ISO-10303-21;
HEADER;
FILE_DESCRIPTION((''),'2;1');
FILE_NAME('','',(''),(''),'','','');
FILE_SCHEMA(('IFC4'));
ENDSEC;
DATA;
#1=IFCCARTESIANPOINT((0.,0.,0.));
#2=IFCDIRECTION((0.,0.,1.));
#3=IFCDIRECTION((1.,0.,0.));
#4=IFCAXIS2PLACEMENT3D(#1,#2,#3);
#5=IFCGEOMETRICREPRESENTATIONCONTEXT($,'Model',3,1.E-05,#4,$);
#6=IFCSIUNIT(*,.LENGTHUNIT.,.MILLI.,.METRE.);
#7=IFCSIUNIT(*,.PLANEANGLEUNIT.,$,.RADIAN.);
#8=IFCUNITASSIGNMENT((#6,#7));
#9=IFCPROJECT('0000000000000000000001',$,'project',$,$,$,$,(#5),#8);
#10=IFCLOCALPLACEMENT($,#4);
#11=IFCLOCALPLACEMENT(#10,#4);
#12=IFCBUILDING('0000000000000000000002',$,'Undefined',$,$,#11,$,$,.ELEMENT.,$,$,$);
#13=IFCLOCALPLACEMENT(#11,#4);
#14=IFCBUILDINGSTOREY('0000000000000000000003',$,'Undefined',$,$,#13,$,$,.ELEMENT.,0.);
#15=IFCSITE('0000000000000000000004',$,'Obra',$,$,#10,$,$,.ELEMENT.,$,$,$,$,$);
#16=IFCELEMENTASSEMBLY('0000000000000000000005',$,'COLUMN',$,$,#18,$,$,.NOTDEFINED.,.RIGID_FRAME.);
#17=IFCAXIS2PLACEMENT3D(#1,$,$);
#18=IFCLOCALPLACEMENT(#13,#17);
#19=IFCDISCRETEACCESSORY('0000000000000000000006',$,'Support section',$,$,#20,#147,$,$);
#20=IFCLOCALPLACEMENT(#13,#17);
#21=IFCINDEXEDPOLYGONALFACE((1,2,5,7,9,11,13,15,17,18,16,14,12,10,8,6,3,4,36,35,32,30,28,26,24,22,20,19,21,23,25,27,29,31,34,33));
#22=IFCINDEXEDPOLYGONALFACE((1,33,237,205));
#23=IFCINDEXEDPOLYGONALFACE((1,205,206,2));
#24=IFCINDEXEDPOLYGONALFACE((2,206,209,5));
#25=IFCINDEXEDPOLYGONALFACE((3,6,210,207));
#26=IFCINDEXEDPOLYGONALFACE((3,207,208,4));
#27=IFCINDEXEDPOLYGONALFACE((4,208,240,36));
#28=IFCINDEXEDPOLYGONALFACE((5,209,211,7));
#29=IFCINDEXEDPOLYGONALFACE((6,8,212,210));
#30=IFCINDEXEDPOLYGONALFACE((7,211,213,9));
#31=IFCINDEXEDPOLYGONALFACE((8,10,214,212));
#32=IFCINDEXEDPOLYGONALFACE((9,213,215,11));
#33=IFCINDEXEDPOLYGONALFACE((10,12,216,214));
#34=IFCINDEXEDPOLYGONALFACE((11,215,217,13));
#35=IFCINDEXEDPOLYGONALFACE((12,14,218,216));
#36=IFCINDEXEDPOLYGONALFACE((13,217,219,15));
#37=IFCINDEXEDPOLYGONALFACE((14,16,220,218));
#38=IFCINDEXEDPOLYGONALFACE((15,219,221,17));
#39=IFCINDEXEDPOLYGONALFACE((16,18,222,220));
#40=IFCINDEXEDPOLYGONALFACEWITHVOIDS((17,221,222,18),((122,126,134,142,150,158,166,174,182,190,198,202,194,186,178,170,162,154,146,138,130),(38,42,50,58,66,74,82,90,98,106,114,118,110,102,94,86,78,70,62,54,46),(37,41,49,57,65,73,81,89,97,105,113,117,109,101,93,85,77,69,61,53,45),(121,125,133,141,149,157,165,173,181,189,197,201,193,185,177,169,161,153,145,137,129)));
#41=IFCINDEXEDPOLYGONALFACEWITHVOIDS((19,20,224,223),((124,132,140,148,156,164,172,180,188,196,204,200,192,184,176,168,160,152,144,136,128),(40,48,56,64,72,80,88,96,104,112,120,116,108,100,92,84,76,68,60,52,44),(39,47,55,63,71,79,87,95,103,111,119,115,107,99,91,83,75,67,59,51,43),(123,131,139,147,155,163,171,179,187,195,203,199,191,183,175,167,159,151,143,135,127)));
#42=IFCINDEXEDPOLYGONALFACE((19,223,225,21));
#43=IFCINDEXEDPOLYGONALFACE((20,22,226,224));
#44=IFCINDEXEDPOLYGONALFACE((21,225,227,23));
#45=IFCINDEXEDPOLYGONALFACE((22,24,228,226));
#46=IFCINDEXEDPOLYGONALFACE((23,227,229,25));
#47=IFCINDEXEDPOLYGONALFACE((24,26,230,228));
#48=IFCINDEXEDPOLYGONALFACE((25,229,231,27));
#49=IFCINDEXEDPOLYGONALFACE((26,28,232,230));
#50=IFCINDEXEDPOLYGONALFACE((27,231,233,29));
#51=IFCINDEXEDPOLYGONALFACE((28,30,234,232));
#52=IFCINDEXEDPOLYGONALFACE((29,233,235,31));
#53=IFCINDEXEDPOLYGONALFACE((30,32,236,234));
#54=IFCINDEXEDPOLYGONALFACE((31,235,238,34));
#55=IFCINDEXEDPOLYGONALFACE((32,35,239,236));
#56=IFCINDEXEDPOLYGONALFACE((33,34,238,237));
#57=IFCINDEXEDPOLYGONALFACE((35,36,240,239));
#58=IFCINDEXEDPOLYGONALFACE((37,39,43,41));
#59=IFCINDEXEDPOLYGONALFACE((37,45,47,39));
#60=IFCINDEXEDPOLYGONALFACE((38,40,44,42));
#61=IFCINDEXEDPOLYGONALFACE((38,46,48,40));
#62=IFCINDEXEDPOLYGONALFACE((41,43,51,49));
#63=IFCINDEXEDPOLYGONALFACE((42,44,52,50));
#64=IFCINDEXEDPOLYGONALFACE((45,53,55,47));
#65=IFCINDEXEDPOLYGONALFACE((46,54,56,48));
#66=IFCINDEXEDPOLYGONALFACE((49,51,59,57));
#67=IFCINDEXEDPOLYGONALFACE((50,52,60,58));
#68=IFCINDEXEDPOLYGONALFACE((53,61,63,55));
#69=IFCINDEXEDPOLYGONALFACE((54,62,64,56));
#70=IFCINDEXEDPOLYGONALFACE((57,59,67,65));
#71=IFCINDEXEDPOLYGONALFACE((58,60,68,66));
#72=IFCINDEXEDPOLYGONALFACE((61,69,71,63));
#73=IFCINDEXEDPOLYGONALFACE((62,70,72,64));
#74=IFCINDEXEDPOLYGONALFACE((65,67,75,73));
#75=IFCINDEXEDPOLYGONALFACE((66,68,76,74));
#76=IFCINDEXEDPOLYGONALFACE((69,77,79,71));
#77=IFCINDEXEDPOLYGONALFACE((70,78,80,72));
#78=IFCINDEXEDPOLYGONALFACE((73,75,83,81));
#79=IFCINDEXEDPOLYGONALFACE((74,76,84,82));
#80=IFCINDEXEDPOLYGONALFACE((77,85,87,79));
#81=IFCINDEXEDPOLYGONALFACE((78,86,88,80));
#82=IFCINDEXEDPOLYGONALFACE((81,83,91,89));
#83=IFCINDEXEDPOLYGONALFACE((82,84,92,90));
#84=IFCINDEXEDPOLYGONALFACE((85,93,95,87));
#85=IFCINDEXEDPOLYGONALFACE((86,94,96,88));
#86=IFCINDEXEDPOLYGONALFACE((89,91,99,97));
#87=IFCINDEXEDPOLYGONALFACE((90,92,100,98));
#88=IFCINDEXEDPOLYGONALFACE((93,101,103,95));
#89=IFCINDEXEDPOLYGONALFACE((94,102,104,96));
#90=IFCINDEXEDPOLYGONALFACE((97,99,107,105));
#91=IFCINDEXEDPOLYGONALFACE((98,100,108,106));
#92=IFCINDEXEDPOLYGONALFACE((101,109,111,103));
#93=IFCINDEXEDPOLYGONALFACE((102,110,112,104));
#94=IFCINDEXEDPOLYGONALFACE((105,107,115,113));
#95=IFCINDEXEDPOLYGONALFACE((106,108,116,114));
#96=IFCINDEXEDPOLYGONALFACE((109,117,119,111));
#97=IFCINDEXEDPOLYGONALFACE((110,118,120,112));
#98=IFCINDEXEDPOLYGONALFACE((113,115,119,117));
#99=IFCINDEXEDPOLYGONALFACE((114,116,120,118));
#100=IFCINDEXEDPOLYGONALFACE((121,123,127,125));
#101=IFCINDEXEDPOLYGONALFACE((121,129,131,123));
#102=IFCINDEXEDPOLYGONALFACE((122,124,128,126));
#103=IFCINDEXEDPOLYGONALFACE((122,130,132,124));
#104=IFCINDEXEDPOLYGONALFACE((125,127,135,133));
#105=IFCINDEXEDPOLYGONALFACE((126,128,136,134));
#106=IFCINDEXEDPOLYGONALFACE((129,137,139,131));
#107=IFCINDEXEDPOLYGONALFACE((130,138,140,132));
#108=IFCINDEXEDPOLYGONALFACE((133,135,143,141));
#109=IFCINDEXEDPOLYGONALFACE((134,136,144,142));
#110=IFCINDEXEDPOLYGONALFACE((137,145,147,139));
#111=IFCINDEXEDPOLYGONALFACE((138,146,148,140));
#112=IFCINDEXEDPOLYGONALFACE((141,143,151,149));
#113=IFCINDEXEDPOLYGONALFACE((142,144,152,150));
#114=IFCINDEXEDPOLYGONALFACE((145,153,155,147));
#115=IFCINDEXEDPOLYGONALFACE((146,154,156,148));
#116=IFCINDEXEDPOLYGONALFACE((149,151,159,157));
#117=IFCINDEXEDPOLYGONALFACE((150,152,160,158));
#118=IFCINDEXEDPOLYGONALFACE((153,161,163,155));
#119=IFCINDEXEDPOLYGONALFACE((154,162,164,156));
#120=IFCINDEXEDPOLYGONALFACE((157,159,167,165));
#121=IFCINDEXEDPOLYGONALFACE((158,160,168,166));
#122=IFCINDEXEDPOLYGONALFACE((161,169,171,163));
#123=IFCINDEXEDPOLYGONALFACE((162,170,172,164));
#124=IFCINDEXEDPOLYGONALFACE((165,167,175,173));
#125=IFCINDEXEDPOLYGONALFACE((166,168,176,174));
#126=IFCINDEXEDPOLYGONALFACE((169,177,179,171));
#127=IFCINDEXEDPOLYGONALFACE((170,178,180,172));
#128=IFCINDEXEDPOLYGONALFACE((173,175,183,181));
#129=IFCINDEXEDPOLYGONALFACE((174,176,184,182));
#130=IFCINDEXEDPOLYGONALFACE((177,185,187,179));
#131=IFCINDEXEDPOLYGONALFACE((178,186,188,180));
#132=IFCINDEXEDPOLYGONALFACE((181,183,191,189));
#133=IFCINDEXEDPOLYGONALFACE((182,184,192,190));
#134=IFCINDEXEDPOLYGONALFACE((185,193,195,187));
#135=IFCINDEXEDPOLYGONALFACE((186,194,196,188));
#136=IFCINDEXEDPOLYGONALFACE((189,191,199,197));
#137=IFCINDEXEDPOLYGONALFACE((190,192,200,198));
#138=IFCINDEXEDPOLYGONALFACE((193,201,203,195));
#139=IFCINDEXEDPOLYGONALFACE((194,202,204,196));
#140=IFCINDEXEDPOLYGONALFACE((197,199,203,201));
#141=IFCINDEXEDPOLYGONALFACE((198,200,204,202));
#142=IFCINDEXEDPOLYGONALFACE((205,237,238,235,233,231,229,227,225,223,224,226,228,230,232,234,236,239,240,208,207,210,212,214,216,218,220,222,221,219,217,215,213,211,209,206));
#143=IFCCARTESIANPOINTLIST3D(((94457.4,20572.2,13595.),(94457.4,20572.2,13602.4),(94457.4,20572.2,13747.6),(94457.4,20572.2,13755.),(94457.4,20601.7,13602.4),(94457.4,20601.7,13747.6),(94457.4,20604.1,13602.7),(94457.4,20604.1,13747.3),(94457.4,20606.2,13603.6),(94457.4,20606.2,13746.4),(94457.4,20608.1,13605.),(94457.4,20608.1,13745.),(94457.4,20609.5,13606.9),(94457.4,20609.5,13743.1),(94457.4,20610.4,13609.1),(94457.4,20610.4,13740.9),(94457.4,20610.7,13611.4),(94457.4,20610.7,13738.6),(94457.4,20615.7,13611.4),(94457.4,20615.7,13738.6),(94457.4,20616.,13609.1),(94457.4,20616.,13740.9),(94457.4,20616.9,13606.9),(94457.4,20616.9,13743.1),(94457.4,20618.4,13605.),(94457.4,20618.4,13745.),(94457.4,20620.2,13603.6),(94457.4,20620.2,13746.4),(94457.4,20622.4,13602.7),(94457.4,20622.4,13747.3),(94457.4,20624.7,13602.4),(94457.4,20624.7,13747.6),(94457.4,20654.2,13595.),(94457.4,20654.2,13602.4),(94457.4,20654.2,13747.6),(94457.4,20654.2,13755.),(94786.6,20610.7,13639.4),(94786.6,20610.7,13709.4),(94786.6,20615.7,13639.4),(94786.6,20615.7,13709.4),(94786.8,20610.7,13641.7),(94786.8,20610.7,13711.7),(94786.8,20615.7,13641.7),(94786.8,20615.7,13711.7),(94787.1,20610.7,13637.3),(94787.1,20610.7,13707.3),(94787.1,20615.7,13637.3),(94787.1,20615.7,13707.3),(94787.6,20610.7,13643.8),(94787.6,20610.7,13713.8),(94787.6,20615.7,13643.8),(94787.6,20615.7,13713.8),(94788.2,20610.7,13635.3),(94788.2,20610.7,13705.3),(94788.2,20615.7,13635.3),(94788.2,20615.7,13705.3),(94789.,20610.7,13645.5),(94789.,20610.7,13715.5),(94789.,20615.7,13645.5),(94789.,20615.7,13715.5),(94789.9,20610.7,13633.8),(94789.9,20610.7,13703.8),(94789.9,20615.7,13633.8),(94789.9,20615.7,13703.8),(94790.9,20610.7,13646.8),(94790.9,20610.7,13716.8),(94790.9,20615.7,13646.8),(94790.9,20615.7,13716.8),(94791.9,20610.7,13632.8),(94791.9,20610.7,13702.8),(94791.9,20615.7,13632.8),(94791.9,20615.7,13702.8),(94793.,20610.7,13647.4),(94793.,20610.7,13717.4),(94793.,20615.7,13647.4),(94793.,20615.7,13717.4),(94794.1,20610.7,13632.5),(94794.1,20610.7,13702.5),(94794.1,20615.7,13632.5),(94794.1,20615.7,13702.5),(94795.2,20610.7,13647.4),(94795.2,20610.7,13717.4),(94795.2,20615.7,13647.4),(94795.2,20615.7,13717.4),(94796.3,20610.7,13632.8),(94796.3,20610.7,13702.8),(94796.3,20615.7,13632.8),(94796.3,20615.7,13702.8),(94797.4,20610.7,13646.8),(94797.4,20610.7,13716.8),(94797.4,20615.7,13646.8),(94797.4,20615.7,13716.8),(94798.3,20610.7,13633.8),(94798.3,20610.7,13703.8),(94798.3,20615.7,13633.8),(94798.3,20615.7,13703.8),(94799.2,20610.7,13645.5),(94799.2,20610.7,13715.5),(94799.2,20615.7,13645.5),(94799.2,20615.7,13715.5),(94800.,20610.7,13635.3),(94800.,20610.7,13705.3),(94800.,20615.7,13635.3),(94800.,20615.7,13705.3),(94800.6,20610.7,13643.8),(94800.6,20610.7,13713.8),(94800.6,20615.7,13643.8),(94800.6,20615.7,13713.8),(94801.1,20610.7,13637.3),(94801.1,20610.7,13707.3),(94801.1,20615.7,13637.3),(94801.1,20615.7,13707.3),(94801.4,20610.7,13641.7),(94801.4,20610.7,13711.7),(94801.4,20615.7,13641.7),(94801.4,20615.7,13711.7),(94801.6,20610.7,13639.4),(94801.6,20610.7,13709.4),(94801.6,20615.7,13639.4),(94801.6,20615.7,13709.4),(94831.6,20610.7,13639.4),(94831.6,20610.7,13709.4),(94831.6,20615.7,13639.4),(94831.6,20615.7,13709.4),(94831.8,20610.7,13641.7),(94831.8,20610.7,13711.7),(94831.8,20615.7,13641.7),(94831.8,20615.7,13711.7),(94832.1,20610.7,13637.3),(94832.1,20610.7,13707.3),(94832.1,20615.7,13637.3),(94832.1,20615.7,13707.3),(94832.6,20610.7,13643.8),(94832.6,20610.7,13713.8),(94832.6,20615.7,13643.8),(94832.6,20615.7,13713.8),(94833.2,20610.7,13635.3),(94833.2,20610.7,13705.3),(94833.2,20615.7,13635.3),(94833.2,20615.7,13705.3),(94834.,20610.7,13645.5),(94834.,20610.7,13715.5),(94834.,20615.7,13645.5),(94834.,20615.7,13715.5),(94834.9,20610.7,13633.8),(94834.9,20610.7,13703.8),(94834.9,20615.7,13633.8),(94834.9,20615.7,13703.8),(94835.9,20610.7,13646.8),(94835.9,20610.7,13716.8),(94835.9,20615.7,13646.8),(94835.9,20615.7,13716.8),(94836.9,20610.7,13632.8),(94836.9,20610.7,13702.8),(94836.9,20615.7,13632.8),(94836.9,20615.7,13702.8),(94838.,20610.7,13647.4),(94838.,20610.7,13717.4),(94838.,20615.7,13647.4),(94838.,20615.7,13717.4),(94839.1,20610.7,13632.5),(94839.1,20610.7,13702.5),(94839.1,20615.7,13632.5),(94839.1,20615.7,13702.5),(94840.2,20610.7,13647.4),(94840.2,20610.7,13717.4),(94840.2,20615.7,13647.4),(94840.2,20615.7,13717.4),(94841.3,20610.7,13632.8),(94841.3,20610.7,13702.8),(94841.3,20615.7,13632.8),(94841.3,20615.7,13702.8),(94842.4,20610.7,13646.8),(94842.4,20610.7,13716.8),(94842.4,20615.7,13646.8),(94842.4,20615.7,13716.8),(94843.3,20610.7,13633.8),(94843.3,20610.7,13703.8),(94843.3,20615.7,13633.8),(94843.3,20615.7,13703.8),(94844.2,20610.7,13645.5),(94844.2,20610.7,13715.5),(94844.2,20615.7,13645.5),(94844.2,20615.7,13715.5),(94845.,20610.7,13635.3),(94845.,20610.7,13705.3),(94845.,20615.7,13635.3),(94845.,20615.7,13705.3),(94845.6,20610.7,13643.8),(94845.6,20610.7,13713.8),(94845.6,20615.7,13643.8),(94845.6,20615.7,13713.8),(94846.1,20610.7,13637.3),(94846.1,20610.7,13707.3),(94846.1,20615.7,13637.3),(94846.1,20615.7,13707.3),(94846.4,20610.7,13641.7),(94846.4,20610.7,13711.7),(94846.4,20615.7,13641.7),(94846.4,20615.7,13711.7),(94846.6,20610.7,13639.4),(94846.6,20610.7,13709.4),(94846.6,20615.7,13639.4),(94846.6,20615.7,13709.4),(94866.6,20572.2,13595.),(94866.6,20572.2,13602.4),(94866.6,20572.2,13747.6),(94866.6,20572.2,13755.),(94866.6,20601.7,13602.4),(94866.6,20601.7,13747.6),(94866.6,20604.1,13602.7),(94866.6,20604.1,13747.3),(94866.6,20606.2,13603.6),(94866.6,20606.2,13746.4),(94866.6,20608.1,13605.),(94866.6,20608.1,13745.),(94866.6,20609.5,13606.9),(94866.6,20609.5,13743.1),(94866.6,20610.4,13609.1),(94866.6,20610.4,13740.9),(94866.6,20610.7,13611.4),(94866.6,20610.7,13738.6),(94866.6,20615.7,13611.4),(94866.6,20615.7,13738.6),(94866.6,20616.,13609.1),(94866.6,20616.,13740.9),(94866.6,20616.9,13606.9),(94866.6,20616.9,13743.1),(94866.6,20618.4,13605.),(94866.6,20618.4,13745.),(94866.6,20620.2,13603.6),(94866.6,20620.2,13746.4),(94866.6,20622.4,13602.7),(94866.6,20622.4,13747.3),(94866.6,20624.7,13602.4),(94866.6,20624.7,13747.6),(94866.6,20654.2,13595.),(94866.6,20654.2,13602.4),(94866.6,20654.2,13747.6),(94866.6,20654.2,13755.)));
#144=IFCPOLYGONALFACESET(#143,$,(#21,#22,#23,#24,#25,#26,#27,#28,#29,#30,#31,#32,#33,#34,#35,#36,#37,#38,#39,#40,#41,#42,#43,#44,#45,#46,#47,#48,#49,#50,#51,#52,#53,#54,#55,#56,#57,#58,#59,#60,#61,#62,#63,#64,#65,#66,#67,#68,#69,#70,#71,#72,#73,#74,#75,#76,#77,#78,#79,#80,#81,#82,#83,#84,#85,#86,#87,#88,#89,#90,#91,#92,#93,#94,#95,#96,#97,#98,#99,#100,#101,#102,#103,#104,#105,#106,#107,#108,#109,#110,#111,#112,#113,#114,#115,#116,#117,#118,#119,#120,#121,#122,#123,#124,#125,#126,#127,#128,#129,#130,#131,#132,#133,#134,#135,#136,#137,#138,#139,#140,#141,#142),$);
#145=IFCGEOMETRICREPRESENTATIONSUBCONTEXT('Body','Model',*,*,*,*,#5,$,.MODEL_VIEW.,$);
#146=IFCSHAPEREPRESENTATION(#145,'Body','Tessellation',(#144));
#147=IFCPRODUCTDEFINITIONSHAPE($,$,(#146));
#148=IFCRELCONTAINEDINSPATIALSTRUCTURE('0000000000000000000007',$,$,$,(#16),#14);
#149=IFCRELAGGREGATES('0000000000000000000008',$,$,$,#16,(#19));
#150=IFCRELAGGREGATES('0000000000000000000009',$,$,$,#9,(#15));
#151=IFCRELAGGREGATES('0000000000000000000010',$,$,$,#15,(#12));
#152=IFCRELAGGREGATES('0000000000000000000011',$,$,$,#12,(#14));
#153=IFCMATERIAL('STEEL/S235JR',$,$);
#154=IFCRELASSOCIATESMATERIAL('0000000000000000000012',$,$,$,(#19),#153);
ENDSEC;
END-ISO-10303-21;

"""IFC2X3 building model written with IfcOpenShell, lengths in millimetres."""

from ifc_helpers import new_model, si_unit, frame, origin_with_axes, origin_2d_with_axis, place, context, subcontext, project, spatial, circle, i_section, extrude, clip, halfspace, source, transform, mapped, material, element, aggregate, save


model = new_model("IFC2X3")

# Units and contexts
model_context = context("Model", 3, precision=1e-05, world=origin_with_axes())
body_context = subcontext(model_context, "Body", "Model", "MODEL_VIEW")
ifc_project = project(units=[si_unit("LENGTHUNIT", "METRE", prefix="MILLI"), si_unit("PLANEANGLEUNIT", "RADIAN")], contexts=[model_context])

# Site, building, storey
site_placement = place(None, origin_with_axes())
site = spatial("IfcSite", under=ifc_project, at=site_placement, Name="Obra", CompositionType="ELEMENT")
building_placement = place(site_placement, origin_with_axes())
building = spatial("IfcBuilding", under=site, at=building_placement, Name="Undefined", CompositionType="ELEMENT")
storey_placement = place(building_placement, origin_with_axes())
storey = spatial("IfcBuildingStorey", under=building, at=storey_placement, Name="Undefined", CompositionType="ELEMENT", Elevation=0.0)

# Shared definitions
ifc_material_1 = material(Name="STEEL/S235JR")

# Element assembly, discrete accessory, opening
assembly_1_placement = place(storey_placement, origin_with_axes())
assembly_1 = element("IfcElementAssembly", 1, at=assembly_1_placement, inside=storey, Name="COLUMN", AssemblyPlace="NOTDEFINED", PredefinedType="RIGID_FRAME")
shared_shape_1 = source(origin_with_axes(), body_context, "Body", "SweptSolid", [
    extrude(circle(Radius=7.5, at=origin_2d_with_axis()), frame((0.0, -2.6, 0.0), z_axis=(0.0, 1.0, 0.0), x_axis=(1.0, 0.0, 0.0)), (0.0, 0.0, 1.0), 5.2),
])
discrete_accessory_1_placement = place(assembly_1_placement, frame((94458.3, 20613.2, 13675.0), z_axis=(0.0, 0.0, 1.0), x_axis=(1.0, 0.0, 0.0)))
discrete_accessory_1 = element("IfcDiscreteAccessory", 2, at=discrete_accessory_1_placement, material=ifc_material_1, Name="Support section", context=body_context, shape_type="Clipping", body=[
    clip(clip(extrude(i_section(OverallWidth=82.0, OverallDepth=160.0, WebThickness=5.0, FlangeThickness=7.4, FilletRadius=9.0, at=origin_2d_with_axis()), frame((408.3, 0.0, 0.0), z_axis=(-1.0, 0.0, 0.0), x_axis=(0.0, -1.0, 0.0)), (0.0, 0.0, 1.0), 409.2), halfspace(frame((408.3, 0.0, -180.0), z_axis=(-1.0, 0.0, 0.0), x_axis=(0.0, 1.0, 0.0)), True)), halfspace(frame((-0.9, 0.0, 580.0), z_axis=(-1.0, -0.000033, 0.0), x_axis=(0.000033, -1.0, 0.0)), False)),
])
opening_1_placement = place(assembly_1_placement, frame((94816.6, 20613.2, 13710.0), z_axis=(-1.0, 0.0, 0.0), x_axis=(0.0, 0.0, -1.0)))
element("IfcOpeningElement", 3, at=opening_1_placement, cuts=discrete_accessory_1, ObjectType="Opening", context=body_context, shape_type="MappedRepresentation", body=[
    mapped(shared_shape_1, transform((0.0, 0.0, -22.5))),
    mapped(shared_shape_1, transform((70.0, 0.0, -22.5))),
    mapped(shared_shape_1, transform((0.0, 0.0, 22.5))),
    mapped(shared_shape_1, transform((70.0, 0.0, 22.5))),
])
aggregate(assembly_1, [discrete_accessory_1])

save(model, "model.ifc")
